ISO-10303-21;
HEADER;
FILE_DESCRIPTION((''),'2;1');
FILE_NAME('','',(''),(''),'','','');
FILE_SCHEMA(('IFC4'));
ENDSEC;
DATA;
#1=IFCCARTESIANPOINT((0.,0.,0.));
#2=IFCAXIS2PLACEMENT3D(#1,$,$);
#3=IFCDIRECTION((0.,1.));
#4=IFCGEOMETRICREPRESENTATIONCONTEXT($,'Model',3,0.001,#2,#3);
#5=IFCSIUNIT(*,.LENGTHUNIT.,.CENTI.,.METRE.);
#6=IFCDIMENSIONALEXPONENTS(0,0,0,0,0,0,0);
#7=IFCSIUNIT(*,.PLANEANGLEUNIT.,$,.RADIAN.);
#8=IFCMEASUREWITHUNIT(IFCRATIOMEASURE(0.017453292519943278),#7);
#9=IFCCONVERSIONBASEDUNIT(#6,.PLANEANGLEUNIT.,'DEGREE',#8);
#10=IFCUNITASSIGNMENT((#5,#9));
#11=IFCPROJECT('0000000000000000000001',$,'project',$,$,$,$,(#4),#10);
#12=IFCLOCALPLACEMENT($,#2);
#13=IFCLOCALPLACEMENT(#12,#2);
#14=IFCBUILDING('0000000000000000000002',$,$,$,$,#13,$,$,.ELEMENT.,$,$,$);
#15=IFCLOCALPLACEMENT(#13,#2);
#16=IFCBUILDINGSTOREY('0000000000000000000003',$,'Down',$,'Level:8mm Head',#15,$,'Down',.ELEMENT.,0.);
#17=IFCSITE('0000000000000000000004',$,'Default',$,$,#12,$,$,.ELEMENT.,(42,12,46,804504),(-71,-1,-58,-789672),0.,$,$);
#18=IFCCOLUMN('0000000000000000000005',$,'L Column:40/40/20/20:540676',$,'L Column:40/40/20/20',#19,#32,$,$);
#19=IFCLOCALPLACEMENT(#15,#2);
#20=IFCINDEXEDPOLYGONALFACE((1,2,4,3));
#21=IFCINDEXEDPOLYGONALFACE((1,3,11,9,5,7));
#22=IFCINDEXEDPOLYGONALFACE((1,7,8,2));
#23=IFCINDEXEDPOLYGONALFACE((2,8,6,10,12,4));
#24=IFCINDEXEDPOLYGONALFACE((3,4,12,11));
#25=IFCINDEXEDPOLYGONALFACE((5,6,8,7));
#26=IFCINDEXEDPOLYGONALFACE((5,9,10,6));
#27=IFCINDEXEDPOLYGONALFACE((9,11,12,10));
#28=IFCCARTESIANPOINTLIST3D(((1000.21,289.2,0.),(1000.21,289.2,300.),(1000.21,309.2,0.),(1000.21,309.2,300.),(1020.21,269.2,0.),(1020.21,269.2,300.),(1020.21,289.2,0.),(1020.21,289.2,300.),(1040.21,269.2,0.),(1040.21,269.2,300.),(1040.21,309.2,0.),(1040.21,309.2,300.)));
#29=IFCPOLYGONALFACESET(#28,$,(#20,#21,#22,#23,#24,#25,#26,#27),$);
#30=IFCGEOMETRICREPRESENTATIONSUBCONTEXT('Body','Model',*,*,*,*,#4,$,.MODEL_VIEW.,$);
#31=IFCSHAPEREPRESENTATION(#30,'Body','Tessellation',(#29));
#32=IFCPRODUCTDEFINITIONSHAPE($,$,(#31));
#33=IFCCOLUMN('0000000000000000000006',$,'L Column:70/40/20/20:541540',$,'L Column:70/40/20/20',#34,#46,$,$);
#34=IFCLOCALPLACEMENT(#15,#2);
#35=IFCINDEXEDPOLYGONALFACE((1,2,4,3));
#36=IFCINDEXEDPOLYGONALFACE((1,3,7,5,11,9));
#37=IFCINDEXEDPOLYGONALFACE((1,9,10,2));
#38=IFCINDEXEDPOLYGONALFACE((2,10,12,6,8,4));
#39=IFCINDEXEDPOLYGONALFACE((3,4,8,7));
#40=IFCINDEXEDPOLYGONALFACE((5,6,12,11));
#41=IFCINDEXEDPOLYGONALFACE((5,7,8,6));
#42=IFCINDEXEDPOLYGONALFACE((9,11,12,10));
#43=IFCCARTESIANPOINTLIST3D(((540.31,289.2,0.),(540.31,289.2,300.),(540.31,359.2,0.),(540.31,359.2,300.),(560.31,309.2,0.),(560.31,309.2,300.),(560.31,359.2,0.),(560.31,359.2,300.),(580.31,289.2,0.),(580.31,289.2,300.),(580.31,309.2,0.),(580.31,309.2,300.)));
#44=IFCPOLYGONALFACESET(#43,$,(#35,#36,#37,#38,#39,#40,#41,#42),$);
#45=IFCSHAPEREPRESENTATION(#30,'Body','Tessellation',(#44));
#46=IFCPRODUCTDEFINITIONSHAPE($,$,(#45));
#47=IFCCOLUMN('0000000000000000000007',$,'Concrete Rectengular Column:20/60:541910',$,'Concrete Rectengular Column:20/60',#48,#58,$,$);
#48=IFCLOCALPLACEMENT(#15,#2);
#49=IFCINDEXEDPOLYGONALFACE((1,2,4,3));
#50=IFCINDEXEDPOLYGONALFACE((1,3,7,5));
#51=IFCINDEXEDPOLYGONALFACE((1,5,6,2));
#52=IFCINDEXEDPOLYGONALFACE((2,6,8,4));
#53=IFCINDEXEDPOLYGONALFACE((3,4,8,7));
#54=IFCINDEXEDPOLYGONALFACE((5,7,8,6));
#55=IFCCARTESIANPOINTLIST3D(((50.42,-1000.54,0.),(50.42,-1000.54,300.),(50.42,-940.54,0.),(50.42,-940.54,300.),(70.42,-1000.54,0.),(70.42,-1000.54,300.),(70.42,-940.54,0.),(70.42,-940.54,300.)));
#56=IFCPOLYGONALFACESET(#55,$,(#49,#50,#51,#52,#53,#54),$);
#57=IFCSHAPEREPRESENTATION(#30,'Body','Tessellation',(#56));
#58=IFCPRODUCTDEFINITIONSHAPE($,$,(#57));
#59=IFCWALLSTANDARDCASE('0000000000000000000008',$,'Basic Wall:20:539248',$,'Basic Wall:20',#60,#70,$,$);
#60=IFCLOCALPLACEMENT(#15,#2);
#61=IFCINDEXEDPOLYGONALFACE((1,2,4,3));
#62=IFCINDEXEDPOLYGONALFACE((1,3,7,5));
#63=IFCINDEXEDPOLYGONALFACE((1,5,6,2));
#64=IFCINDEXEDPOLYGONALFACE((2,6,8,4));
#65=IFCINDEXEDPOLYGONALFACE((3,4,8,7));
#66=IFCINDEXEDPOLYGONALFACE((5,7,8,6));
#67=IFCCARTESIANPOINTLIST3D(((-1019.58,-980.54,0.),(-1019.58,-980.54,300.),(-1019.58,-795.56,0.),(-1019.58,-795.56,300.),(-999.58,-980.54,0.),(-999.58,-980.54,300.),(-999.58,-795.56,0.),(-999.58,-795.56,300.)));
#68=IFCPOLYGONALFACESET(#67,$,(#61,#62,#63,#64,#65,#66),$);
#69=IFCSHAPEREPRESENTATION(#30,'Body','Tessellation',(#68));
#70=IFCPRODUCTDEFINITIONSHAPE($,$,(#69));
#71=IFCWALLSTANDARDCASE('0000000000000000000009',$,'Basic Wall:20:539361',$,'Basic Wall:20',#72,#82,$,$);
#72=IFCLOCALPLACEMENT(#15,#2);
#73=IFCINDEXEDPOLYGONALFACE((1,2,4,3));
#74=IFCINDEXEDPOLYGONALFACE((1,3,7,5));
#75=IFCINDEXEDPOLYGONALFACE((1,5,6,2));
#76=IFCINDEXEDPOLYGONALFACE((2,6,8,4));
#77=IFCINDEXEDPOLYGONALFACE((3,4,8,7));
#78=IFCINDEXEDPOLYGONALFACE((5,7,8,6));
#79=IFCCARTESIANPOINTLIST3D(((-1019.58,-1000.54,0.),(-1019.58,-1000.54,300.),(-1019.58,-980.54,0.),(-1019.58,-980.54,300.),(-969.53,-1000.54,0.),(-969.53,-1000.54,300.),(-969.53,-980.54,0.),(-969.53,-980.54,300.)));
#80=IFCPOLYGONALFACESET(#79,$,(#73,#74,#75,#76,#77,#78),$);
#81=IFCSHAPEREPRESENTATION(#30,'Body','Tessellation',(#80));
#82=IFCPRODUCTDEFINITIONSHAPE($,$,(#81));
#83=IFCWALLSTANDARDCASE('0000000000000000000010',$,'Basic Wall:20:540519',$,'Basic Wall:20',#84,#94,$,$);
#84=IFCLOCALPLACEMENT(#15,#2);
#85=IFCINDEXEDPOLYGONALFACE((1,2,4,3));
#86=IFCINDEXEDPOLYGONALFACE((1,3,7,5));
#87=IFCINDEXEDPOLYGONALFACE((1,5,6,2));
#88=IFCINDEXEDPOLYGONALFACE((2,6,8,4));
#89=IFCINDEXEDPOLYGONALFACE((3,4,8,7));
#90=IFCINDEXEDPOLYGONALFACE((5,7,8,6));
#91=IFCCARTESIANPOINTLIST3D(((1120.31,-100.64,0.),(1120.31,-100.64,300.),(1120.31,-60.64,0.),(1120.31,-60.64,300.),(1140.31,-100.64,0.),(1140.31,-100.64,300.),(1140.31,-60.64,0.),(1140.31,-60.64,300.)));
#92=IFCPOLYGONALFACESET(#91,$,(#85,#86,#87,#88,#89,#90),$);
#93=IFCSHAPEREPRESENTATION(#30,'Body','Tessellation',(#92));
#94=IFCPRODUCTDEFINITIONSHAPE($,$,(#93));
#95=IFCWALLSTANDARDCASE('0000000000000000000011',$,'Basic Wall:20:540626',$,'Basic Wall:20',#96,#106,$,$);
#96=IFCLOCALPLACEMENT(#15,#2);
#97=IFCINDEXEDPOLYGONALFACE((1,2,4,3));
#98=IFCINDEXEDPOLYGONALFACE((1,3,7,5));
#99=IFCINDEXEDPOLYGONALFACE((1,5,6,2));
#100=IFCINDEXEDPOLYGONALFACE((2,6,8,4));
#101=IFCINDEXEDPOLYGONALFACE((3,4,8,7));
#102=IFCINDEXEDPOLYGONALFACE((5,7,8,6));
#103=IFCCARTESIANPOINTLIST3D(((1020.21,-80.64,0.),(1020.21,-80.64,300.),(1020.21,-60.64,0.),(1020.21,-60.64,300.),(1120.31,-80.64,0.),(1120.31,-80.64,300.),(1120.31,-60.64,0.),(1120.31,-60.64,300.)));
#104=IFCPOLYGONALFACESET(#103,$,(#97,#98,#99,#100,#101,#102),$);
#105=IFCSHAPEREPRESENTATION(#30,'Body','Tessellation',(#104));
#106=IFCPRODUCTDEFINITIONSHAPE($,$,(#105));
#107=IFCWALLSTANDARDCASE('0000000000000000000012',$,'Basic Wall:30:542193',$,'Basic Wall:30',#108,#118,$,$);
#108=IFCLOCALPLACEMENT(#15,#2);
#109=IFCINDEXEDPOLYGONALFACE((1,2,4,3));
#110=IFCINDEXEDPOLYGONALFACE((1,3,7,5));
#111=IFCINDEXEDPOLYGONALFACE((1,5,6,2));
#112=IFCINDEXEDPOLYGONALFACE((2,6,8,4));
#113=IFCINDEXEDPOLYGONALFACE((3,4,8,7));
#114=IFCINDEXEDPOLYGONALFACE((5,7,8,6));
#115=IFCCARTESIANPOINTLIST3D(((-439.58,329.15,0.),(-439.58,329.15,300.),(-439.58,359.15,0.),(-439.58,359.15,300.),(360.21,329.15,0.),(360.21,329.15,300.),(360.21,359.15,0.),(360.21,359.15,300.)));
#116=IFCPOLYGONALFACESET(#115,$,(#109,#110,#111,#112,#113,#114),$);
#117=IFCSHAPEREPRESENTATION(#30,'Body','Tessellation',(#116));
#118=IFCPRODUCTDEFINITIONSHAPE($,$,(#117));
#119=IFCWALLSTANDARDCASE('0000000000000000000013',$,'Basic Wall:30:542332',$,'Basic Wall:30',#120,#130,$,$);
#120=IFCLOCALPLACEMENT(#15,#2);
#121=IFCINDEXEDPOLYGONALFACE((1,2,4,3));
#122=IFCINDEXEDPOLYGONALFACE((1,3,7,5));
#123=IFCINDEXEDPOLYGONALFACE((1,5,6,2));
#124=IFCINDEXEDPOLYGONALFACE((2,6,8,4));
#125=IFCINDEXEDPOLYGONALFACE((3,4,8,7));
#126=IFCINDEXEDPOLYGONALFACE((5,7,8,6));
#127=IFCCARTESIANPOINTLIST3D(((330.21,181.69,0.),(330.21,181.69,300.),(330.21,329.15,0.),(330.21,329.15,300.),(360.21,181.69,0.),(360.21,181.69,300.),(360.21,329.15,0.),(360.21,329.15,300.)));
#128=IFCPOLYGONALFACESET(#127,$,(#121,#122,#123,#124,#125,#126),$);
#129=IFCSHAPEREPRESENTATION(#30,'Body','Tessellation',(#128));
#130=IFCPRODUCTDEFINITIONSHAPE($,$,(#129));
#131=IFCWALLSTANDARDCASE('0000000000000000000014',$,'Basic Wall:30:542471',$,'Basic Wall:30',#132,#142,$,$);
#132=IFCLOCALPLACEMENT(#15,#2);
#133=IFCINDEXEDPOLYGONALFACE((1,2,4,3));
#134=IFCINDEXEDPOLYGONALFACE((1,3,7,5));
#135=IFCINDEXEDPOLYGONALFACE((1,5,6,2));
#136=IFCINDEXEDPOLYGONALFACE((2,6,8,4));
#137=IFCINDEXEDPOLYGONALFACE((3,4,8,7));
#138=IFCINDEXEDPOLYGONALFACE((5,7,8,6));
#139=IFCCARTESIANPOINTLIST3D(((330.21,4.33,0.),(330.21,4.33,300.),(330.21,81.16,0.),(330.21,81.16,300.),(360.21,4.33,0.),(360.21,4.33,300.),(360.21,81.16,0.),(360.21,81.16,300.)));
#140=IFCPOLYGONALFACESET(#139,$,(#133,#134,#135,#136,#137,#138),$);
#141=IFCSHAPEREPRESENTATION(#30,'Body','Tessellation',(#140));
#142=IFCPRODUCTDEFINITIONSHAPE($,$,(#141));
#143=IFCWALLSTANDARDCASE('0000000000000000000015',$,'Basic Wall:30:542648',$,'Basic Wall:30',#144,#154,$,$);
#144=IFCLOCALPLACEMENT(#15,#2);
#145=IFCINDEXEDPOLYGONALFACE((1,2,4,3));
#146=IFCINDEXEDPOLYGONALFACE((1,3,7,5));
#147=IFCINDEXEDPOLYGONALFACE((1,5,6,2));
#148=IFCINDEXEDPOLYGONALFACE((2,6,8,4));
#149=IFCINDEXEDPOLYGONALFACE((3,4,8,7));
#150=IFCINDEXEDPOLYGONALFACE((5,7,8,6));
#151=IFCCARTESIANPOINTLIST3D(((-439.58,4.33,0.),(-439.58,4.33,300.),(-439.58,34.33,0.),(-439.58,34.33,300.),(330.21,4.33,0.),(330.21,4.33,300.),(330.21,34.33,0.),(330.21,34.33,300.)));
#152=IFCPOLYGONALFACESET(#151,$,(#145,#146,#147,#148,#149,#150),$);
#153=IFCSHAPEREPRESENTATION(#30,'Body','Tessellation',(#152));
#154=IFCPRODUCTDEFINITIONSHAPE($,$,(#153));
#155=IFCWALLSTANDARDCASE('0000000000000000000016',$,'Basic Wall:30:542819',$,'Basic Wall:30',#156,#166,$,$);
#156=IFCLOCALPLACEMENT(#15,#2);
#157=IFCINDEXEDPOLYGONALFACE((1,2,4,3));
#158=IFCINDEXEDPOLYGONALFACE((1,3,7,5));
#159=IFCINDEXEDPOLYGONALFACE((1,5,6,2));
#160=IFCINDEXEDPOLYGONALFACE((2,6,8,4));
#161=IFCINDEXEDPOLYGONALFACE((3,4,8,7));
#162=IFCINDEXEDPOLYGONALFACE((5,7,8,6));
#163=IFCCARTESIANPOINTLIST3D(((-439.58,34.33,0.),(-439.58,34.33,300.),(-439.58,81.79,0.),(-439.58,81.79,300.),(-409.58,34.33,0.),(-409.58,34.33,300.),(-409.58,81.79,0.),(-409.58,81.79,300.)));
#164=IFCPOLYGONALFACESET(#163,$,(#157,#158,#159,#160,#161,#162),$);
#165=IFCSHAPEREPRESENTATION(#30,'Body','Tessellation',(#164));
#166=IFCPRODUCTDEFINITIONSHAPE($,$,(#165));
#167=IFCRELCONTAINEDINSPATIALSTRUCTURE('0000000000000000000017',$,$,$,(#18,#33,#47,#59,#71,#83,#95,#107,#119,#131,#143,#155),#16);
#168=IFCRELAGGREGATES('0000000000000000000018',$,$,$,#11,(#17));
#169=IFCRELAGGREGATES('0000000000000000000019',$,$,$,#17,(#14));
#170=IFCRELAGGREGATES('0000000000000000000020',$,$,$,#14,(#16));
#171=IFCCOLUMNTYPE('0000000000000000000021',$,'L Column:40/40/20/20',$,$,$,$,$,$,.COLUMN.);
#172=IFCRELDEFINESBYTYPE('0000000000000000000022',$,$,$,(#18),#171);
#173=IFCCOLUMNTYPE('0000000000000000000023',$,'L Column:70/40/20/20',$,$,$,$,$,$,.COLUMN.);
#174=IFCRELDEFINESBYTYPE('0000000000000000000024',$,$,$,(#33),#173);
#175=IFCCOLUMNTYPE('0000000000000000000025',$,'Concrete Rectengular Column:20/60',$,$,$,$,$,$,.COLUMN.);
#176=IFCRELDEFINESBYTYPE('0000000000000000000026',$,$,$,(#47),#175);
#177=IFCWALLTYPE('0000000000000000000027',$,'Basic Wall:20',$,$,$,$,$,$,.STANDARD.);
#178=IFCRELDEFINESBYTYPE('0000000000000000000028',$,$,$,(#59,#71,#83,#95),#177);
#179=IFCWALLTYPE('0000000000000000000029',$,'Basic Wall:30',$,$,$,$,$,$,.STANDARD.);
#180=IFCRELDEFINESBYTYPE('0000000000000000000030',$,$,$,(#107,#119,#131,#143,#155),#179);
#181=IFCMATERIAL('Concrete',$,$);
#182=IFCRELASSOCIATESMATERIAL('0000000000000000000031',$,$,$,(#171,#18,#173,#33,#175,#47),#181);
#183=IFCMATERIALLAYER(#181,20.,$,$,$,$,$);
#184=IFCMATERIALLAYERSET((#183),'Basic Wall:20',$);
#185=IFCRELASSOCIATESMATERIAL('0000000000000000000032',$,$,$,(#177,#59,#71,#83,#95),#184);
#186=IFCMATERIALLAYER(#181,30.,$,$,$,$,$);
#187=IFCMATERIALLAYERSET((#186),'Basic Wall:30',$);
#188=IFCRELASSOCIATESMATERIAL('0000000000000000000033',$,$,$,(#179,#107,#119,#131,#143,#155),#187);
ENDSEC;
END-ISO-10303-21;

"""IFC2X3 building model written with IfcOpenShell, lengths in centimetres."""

from ifc_helpers import new_model, entity, si_unit, converted_unit, direction, frame, frame_2d, origin, origin_2d_with_axis, place, context, subcontext, project, spatial, polyline, rectangle, outline, extrude, source, transform, mapped, material, layer, layer_set, layer_usage, type_object, type_shapes, element, save


model = new_model("IFC2X3")

# Units and contexts
model_context = context("Model", 3, precision=0.001, world=origin(), true_north=direction((0.0, 1.0)))
body_context = subcontext(model_context, "Body", "Model", "MODEL_VIEW")
ifc_project = project(units=[si_unit("LENGTHUNIT", "METRE", prefix="CENTI"), converted_unit("PLANEANGLEUNIT", "DEGREE", entity("IfcRatioMeasure", 0.017453292519943278), si_unit("PLANEANGLEUNIT", "RADIAN"), dimensions=[0, 0, 0, 0, 0, 0, 0])], contexts=[model_context])

# Site, building, storey
site_placement = place(None, origin())
site = spatial("IfcSite", under=ifc_project, at=site_placement, Name="Default", CompositionType="ELEMENT", RefLatitude=(42, 12, 46, 804504), RefLongitude=(-71, -1, -58, -789672), RefElevation=0.0)
building_placement = place(site_placement, origin())
building = spatial("IfcBuilding", under=site, at=building_placement, CompositionType="ELEMENT")
storey_placement = place(building_placement, origin())
storey = spatial("IfcBuildingStorey", under=building, at=storey_placement, Name="Down", ObjectType="Level:8mm Head", LongName="Down", CompositionType="ELEMENT", Elevation=0.0)

# Columns
ifc_material = material(Name="Concrete")
column_type_1 = type_object("IfcColumnType", Name="L Column:40/40/20/20", PredefinedType="COLUMN", material=ifc_material)
shared_shape_1 = source(origin(), body_context, "Body", "SweptSolid", [
    extrude(outline(polyline([(-20.0, -20.0), (0.0, -20.0), (0.0, 0.0), (20.0, 0.0), (20.0, 20.0), (-20.0, 20.0), (-20.0, -20.0)])), frame((1020.21, 289.2, 0.0), z_axis=(0.0, 0.0, 1.0), x_axis=(0.0, -1.0, 0.0)), (0.0, 0.0, 1.0), 300.0),
])
type_shapes(column_type_1, [shared_shape_1])
column_1_placement = place(storey_placement, origin())
element("IfcColumn", 1, at=column_1_placement, inside=storey, type_object=column_type_1, material=ifc_material, Name="L Column:40/40/20/20:540676", ObjectType="L Column:40/40/20/20", context=body_context, shape_type="MappedRepresentation", body=[
    mapped(shared_shape_1, transform((0.0, 0.0, 0.0), scale=1.0)),
])
column_type_2 = type_object("IfcColumnType", Name="L Column:70/40/20/20", PredefinedType="COLUMN", material=ifc_material)
shared_shape_2 = source(origin(), body_context, "Body", "SweptSolid", [
    extrude(outline(polyline([(-40.0, -20.0), (30.0, -20.0), (30.0, 20.0), (10.0, 20.0), (10.0, 0.0), (-40.0, 0.0), (-40.0, -20.0)])), frame((560.31, 319.2, 0.0), z_axis=(0.0, 0.0, 1.0), x_axis=(0.0, -1.0, 0.0)), (0.0, 0.0, 1.0), 300.0),
])
type_shapes(column_type_2, [shared_shape_2])
column_2_placement = place(storey_placement, origin())
element("IfcColumn", 2, at=column_2_placement, inside=storey, type_object=column_type_2, material=ifc_material, Name="L Column:70/40/20/20:541540", ObjectType="L Column:70/40/20/20", context=body_context, shape_type="MappedRepresentation", body=[
    mapped(shared_shape_2, transform((0.0, 0.0, 0.0), scale=1.0)),
])
column_type_3 = type_object("IfcColumnType", Name="Concrete Rectengular Column:20/60", PredefinedType="COLUMN", material=ifc_material)
shared_shape_3 = source(origin(), body_context, "Body", "SweptSolid", [
    extrude(rectangle(XDim=60.0, YDim=20.0, at=origin_2d_with_axis()), frame((60.42, -970.54, 0.0), z_axis=(0.0, 0.0, 1.0), x_axis=(0.0, -1.0, 0.0)), (0.0, 0.0, 1.0), 300.0),
])
type_shapes(column_type_3, [shared_shape_3])
column_3_placement = place(storey_placement, origin())
element("IfcColumn", 3, at=column_3_placement, inside=storey, type_object=column_type_3, material=ifc_material, Name="Concrete Rectengular Column:20/60:541910", ObjectType="Concrete Rectengular Column:20/60", context=body_context, shape_type="MappedRepresentation", body=[
    mapped(shared_shape_3, transform((0.0, 0.0, 0.0), scale=1.0)),
])

# Walls
ifc_layer_1 = layer(ifc_material, 20.0)
ifc_layer_set_1 = layer_set([ifc_layer_1], Name="Basic Wall:20")
ifc_layer_usage_1 = layer_usage(ifc_layer_set_1, "AXIS2", "NEGATIVE", 10.0)
wall_type_1 = type_object("IfcWallType", Name="Basic Wall:20", PredefinedType="STANDARD", material=ifc_layer_set_1)
wall_1_placement = place(storey_placement, frame((-1009.58, -795.56, 0.0), z_axis=(0.0, 0.0, 1.0), x_axis=(0.0, -1.0, 0.0)))
element("IfcWallStandardCase", 4, at=wall_1_placement, inside=storey, type_object=wall_type_1, material=ifc_layer_usage_1, Name="Basic Wall:20:539248", ObjectType="Basic Wall:20", context=body_context, shape_type="SweptSolid", body=[
    extrude(rectangle(XDim=184.97, YDim=20.0, at=frame_2d((92.49, 0.0), x_axis=(-1.0, 0.0))), origin(), (0.0, 0.0, 1.0), 300.0),
])
ifc_layer_usage_2 = layer_usage(ifc_layer_set_1, "AXIS2", "POSITIVE", -10.0)
wall_2_placement = place(storey_placement, frame((-1019.58, -990.54, 0.0)))
element("IfcWallStandardCase", 5, at=wall_2_placement, inside=storey, type_object=wall_type_1, material=ifc_layer_usage_2, Name="Basic Wall:20:539361", ObjectType="Basic Wall:20", context=body_context, shape_type="SweptSolid", body=[
    extrude(rectangle(XDim=50.05, YDim=20.0, at=frame_2d((25.03, 0.0), x_axis=(-1.0, 0.0))), origin(), (0.0, 0.0, 1.0), 300.0),
])
ifc_layer_usage_3 = layer_usage(ifc_layer_set_1, "AXIS2", "POSITIVE", -10.0)
wall_3_placement = place(storey_placement, frame((1130.31, -100.64, 0.0), z_axis=(0.0, 0.0, 1.0), x_axis=(0.0, 1.0, 0.0)))
element("IfcWallStandardCase", 6, at=wall_3_placement, inside=storey, type_object=wall_type_1, material=ifc_layer_usage_3, Name="Basic Wall:20:540519", ObjectType="Basic Wall:20", context=body_context, shape_type="SweptSolid", body=[
    extrude(rectangle(XDim=40.0, YDim=20.0, at=frame_2d((20.0, 0.0), x_axis=(-1.0, 0.0))), origin(), (0.0, 0.0, 1.0), 300.0),
])
ifc_layer_usage_4 = layer_usage(ifc_layer_set_1, "AXIS2", "POSITIVE", -10.0)
wall_4_placement = place(storey_placement, frame((1120.31, -70.64, 0.0), z_axis=(0.0, 0.0, 1.0), x_axis=(-1.0, 0.0, 0.0)))
element("IfcWallStandardCase", 7, at=wall_4_placement, inside=storey, type_object=wall_type_1, material=ifc_layer_usage_4, Name="Basic Wall:20:540626", ObjectType="Basic Wall:20", context=body_context, shape_type="SweptSolid", body=[
    extrude(rectangle(XDim=100.11, YDim=20.0, at=frame_2d((50.05, 0.0), x_axis=(-1.0, 0.0))), origin(), (0.0, 0.0, 1.0), 300.0),
])
ifc_layer_2 = layer(ifc_material, 30.0)
ifc_layer_set_2 = layer_set([ifc_layer_2], Name="Basic Wall:30")
ifc_layer_usage_5 = layer_usage(ifc_layer_set_2, "AXIS2", "NEGATIVE", 15.0)
wall_type_2 = type_object("IfcWallType", Name="Basic Wall:30", PredefinedType="STANDARD", material=ifc_layer_set_2)
wall_5_placement = place(storey_placement, frame((-439.58, 344.15, 0.0)))
element("IfcWallStandardCase", 8, at=wall_5_placement, inside=storey, type_object=wall_type_2, material=ifc_layer_usage_5, Name="Basic Wall:30:542193", ObjectType="Basic Wall:30", context=body_context, shape_type="SweptSolid", body=[
    extrude(rectangle(XDim=799.79, YDim=30.0, at=frame_2d((399.89, 0.0), x_axis=(-1.0, 0.0))), origin(), (0.0, 0.0, 1.0), 300.0),
])
ifc_layer_usage_6 = layer_usage(ifc_layer_set_2, "AXIS2", "NEGATIVE", 15.0)
wall_6_placement = place(storey_placement, frame((345.21, 329.15, 0.0), z_axis=(0.0, 0.0, 1.0), x_axis=(0.0, -1.0, 0.0)))
element("IfcWallStandardCase", 9, at=wall_6_placement, inside=storey, type_object=wall_type_2, material=ifc_layer_usage_6, Name="Basic Wall:30:542332", ObjectType="Basic Wall:30", context=body_context, shape_type="SweptSolid", body=[
    extrude(rectangle(XDim=147.46, YDim=30.0, at=frame_2d((73.73, 0.0), x_axis=(-1.0, 0.0))), origin(), (0.0, 0.0, 1.0), 300.0),
])
ifc_layer_usage_7 = layer_usage(ifc_layer_set_2, "AXIS2", "NEGATIVE", 15.0)
wall_7_placement = place(storey_placement, frame((345.21, 81.16, 0.0), z_axis=(0.0, 0.0, 1.0), x_axis=(0.0, -1.0, 0.0)))
element("IfcWallStandardCase", 10, at=wall_7_placement, inside=storey, type_object=wall_type_2, material=ifc_layer_usage_7, Name="Basic Wall:30:542471", ObjectType="Basic Wall:30", context=body_context, shape_type="SweptSolid", body=[
    extrude(rectangle(XDim=76.83, YDim=30.0, at=frame_2d((38.41, 0.0), x_axis=(-1.0, 0.0))), origin(), (0.0, 0.0, 1.0), 300.0),
])
ifc_layer_usage_8 = layer_usage(ifc_layer_set_2, "AXIS2", "NEGATIVE", 15.0)
wall_8_placement = place(storey_placement, frame((330.21, 19.33, 0.0), z_axis=(0.0, 0.0, 1.0), x_axis=(-1.0, 0.0, 0.0)))
element("IfcWallStandardCase", 11, at=wall_8_placement, inside=storey, type_object=wall_type_2, material=ifc_layer_usage_8, Name="Basic Wall:30:542648", ObjectType="Basic Wall:30", context=body_context, shape_type="SweptSolid", body=[
    extrude(rectangle(XDim=769.79, YDim=30.0, at=frame_2d((384.89, 0.0), x_axis=(-1.0, 0.0))), origin(), (0.0, 0.0, 1.0), 300.0),
])
ifc_layer_usage_9 = layer_usage(ifc_layer_set_2, "AXIS2", "NEGATIVE", 15.0)
wall_9_placement = place(storey_placement, frame((-424.58, 34.33, 0.0), z_axis=(0.0, 0.0, 1.0), x_axis=(0.0, 1.0, 0.0)))
element("IfcWallStandardCase", 12, at=wall_9_placement, inside=storey, type_object=wall_type_2, material=ifc_layer_usage_9, Name="Basic Wall:30:542819", ObjectType="Basic Wall:30", context=body_context, shape_type="SweptSolid", body=[
    extrude(rectangle(XDim=47.46, YDim=30.0, at=frame_2d((23.73, 0.0), x_axis=(-1.0, 0.0))), origin(), (0.0, 0.0, 1.0), 300.0),
])

save(model, "model.ifc")
